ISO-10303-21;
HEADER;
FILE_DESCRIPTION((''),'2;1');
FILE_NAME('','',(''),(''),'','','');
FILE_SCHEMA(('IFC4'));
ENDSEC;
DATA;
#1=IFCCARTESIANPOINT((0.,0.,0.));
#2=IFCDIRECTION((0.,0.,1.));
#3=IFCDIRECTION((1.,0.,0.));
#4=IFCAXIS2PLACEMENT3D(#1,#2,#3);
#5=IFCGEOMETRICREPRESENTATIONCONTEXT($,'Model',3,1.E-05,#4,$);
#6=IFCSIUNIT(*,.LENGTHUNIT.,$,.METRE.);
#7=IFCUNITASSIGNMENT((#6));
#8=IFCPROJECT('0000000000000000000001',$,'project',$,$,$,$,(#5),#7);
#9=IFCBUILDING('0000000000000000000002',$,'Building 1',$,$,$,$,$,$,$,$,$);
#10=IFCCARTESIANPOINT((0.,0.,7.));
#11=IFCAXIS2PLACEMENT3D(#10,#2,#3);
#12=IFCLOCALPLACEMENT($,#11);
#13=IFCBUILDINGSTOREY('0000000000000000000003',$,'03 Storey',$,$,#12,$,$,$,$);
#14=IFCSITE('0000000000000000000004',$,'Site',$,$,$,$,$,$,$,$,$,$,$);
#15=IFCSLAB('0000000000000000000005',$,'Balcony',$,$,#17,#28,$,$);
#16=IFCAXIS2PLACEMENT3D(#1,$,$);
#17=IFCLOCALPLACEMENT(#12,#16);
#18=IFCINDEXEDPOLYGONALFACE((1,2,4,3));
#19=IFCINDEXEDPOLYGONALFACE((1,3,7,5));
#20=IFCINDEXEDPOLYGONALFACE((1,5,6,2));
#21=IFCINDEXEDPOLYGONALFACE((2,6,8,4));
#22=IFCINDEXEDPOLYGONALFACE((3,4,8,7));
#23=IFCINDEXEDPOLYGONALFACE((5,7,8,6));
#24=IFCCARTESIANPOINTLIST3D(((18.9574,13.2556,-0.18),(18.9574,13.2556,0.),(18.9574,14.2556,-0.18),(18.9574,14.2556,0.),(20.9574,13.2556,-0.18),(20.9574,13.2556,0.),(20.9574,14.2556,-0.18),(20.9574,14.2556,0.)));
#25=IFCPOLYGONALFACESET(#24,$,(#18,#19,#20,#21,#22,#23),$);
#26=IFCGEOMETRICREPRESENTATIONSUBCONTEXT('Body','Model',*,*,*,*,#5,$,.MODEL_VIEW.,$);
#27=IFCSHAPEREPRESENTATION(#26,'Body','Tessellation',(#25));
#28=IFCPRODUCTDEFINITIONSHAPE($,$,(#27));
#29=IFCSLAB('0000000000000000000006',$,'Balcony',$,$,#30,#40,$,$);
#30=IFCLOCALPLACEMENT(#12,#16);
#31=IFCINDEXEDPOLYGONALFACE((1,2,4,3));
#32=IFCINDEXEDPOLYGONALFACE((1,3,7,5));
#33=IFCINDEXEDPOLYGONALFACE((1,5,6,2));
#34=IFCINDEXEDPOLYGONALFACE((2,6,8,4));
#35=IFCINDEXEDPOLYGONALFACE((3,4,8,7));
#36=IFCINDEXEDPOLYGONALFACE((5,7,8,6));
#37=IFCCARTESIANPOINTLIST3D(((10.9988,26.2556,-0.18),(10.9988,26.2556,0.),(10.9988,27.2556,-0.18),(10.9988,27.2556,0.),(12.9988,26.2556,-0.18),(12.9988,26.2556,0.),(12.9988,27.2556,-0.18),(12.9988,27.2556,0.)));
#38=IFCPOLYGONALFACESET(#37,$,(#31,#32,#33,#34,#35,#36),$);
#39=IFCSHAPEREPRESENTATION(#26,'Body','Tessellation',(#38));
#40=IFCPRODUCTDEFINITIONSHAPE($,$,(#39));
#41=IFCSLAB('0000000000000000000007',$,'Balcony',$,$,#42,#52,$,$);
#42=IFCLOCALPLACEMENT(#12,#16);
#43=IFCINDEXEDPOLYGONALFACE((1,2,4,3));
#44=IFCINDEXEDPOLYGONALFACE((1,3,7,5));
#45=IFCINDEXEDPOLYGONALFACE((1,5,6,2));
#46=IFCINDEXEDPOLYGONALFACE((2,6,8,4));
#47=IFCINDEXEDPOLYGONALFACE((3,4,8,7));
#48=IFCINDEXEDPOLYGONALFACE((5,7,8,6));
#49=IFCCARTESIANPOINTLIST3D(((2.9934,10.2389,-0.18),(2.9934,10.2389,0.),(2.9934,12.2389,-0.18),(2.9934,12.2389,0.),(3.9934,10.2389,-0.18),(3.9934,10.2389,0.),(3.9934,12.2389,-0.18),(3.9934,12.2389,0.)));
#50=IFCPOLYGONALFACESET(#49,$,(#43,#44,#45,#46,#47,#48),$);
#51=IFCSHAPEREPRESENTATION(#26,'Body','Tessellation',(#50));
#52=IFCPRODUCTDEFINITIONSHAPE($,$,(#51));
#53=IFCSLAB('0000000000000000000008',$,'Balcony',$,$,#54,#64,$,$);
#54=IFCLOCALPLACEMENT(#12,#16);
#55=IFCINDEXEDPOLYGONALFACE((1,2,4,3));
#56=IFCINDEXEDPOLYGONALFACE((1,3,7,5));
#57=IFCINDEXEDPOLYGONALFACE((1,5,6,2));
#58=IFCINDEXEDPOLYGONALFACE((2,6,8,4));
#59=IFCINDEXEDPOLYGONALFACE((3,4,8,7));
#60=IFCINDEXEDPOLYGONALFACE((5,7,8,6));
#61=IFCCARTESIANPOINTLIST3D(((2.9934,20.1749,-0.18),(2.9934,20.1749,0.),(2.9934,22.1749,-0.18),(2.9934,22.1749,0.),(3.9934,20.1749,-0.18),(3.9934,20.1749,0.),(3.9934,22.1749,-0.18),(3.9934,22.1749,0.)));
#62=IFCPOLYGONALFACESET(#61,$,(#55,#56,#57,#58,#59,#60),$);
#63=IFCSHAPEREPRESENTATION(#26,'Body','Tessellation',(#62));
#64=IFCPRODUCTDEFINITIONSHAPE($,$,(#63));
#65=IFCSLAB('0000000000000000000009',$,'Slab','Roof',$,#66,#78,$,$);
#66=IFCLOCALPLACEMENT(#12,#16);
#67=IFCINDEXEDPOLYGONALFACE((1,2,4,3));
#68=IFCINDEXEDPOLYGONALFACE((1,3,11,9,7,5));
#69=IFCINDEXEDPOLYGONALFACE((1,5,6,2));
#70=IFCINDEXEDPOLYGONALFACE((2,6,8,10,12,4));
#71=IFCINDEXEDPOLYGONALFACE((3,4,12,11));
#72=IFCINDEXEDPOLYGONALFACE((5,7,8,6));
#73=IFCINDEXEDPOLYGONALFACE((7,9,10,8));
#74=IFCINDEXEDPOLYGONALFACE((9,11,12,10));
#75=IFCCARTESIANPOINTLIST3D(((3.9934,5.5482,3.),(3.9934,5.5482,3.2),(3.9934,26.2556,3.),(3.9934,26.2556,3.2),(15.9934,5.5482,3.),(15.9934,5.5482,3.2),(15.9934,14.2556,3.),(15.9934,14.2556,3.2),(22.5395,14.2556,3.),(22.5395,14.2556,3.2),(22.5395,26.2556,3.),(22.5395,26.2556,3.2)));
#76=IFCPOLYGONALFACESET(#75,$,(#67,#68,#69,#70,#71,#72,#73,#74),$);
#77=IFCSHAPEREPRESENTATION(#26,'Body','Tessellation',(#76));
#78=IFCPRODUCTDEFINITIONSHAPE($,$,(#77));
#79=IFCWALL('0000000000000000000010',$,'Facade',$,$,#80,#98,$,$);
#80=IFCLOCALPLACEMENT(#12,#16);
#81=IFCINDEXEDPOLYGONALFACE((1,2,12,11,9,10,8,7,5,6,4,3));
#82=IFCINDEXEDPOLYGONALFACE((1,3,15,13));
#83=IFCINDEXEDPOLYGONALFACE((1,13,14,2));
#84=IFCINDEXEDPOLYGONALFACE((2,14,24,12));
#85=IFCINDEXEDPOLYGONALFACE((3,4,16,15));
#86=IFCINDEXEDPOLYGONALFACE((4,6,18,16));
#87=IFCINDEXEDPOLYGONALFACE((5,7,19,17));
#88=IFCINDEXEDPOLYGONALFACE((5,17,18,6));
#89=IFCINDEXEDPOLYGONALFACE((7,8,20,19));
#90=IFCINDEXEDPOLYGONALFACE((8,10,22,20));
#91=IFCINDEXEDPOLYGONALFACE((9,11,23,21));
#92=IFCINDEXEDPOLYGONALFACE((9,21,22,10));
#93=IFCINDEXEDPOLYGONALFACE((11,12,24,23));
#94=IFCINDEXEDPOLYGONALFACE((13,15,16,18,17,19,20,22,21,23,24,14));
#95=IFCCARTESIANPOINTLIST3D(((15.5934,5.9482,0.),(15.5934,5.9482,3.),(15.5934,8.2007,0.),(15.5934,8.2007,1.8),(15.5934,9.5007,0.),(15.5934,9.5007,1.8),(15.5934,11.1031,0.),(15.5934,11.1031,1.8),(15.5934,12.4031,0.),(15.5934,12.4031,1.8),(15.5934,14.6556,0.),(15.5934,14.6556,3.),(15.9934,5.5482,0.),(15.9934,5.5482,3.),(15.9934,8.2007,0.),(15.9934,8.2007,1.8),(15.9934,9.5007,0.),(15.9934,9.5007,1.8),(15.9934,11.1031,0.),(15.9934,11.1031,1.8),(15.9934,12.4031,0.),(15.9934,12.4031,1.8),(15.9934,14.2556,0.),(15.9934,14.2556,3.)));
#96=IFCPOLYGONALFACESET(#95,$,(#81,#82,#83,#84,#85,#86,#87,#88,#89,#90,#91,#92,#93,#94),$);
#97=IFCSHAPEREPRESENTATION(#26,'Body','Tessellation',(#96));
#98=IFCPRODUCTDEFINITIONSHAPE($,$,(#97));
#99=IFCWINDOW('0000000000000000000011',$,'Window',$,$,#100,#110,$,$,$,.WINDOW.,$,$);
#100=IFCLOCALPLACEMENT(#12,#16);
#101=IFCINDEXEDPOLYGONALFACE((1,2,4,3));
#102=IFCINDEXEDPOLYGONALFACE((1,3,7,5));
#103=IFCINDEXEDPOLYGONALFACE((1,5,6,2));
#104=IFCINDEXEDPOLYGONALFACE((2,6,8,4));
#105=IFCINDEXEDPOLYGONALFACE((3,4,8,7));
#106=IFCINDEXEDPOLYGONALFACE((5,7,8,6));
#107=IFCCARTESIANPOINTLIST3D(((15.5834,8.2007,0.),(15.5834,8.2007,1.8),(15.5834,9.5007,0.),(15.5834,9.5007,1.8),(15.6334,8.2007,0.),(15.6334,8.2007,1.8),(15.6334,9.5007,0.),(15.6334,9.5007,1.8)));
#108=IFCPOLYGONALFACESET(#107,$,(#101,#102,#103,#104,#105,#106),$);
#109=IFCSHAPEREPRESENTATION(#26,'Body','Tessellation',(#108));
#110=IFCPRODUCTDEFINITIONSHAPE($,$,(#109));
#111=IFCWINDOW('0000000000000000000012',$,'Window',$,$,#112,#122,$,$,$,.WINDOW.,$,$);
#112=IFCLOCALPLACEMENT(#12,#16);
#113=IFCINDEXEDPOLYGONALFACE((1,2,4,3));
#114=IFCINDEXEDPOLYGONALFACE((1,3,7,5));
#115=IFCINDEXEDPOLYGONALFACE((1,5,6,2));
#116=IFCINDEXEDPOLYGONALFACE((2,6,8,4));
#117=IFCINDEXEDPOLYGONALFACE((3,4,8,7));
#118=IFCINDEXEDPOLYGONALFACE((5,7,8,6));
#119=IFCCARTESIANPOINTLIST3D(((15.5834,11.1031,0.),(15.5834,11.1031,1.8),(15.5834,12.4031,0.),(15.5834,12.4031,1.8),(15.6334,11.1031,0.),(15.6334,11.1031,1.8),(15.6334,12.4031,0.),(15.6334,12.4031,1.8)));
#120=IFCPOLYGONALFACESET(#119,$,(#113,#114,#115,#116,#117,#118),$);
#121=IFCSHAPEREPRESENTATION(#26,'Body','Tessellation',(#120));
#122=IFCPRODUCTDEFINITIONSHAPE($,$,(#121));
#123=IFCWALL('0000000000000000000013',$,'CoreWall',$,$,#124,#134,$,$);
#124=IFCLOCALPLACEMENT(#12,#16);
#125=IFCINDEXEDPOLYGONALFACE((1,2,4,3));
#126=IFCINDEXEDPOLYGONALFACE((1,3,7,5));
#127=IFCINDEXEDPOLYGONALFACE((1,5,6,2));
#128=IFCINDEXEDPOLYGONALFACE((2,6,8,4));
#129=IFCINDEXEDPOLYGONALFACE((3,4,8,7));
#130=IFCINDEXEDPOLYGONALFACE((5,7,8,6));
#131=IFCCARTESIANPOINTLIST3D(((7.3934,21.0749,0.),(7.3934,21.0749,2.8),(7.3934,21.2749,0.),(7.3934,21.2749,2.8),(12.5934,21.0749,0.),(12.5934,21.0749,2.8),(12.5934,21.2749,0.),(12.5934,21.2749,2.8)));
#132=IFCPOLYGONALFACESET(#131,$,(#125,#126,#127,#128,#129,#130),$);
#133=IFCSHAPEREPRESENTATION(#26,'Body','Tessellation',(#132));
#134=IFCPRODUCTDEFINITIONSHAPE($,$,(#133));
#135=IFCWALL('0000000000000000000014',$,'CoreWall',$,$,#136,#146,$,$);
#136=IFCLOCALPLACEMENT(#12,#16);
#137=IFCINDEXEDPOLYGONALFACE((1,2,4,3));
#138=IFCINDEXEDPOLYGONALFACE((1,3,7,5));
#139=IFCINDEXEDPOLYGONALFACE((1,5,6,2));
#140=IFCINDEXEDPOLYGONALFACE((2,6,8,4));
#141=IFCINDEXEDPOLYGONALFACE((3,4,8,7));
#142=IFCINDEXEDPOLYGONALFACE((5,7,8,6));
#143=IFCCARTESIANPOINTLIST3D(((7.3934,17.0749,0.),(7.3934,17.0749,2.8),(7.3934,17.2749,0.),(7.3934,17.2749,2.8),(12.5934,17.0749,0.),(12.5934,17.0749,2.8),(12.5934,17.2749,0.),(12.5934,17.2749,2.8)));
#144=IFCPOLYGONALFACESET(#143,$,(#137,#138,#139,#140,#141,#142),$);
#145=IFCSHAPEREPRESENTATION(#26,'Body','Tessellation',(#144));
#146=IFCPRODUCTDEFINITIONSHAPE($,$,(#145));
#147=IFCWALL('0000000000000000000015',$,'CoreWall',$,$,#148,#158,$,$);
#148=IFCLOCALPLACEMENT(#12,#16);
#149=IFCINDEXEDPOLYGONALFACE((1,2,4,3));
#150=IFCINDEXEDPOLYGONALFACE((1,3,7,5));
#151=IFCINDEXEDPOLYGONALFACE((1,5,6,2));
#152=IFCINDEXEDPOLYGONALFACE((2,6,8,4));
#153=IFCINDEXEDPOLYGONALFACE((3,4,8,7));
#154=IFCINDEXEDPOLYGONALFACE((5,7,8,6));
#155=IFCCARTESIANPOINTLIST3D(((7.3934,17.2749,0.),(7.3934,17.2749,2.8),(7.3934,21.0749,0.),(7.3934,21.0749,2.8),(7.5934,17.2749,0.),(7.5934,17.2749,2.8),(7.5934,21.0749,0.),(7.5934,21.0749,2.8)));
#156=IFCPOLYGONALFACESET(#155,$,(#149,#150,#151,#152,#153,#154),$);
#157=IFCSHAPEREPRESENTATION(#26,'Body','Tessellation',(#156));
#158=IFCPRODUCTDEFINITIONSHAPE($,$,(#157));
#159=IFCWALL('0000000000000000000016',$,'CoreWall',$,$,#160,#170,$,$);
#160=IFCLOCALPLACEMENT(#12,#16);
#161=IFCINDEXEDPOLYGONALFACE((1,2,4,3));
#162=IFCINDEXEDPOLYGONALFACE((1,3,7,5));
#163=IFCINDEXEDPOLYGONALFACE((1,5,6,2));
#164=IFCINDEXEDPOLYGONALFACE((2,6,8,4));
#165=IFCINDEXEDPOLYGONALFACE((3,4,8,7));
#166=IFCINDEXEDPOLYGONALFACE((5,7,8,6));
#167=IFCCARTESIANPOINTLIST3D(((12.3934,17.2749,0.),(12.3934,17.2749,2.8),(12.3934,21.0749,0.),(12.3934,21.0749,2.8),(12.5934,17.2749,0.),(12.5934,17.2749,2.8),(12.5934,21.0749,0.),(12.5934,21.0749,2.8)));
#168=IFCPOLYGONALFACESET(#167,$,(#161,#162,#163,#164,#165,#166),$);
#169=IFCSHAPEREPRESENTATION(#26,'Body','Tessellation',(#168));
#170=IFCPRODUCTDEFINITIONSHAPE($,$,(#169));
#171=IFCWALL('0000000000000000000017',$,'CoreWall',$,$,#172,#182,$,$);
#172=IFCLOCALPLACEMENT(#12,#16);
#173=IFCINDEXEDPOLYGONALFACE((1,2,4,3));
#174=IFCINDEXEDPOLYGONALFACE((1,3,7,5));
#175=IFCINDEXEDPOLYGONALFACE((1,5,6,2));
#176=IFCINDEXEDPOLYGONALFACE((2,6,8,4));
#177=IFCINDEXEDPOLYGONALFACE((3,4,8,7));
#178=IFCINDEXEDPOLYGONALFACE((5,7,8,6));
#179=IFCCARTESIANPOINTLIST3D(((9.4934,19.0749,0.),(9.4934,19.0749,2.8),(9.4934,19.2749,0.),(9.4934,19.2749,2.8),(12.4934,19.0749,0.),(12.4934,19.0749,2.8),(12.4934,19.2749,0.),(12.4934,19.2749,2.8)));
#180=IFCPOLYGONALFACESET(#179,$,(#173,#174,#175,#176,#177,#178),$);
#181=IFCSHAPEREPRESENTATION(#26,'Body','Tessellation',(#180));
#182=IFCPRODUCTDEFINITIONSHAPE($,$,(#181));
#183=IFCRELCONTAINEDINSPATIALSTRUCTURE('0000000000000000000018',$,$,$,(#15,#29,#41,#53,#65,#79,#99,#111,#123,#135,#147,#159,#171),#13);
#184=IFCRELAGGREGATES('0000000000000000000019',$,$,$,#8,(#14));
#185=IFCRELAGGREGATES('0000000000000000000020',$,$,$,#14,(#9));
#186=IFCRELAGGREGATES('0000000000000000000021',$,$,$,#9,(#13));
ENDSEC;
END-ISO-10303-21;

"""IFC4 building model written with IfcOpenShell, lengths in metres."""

from ifc_helpers import new_model, si_unit, frame, origin_with_axes, place, context, subcontext, project, spatial, polyline, line, indexed_curve, outline, extrude, element, fill, save


model = new_model("IFC4")

# Units and contexts
model_context = context("Model", 3, precision=1e-05, world=origin_with_axes())
body_context = subcontext(model_context, "Body", "Model", "MODEL_VIEW")
ifc_project = project(units=[si_unit("LENGTHUNIT", "METRE")], contexts=[model_context])

# Site, building, storey
site = spatial("IfcSite", under=ifc_project, Name="Site")
building = spatial("IfcBuilding", under=site, Name="Building 1")
storey_placement = place(None, frame((0.0, 0.0, 7.0), z_axis=(0.0, 0.0, 1.0), x_axis=(1.0, 0.0, 0.0)))
storey = spatial("IfcBuildingStorey", under=building, at=storey_placement, Name="03 Storey")

# Slabs
slab_1_placement = place(storey_placement, origin_with_axes())
element("IfcSlab", 1, at=slab_1_placement, inside=storey, Name="Balcony", context=body_context, shape_type="SweptSolid", body=[
    extrude(outline(indexed_curve([(20.9574, 14.2556), (20.9574, 13.2556), (18.9574, 13.2556), (18.9574, 14.2556)], segments=[line(1, 2), line(2, 3), line(3, 4)])), origin_with_axes(), (0.0, 0.0, -1.0), 0.18),
])
slab_2_placement = place(storey_placement, origin_with_axes())
element("IfcSlab", 2, at=slab_2_placement, inside=storey, Name="Balcony", context=body_context, shape_type="SweptSolid", body=[
    extrude(outline(indexed_curve([(10.9988, 26.2556), (10.9988, 27.2556), (12.9988, 27.2556), (12.9988, 26.2556)], segments=[line(1, 2), line(2, 3), line(3, 4)])), origin_with_axes(), (0.0, 0.0, -1.0), 0.18),
])
slab_3_placement = place(storey_placement, origin_with_axes())
element("IfcSlab", 3, at=slab_3_placement, inside=storey, Name="Balcony", context=body_context, shape_type="SweptSolid", body=[
    extrude(outline(indexed_curve([(3.9934, 10.2389), (2.9934, 10.2389), (2.9934, 12.2389), (3.9934, 12.2389)], segments=[line(1, 2), line(2, 3), line(3, 4)])), origin_with_axes(), (0.0, 0.0, -1.0), 0.18),
])
slab_4_placement = place(storey_placement, origin_with_axes())
element("IfcSlab", 4, at=slab_4_placement, inside=storey, Name="Balcony", context=body_context, shape_type="SweptSolid", body=[
    extrude(outline(indexed_curve([(3.9934, 20.1749), (2.9934, 20.1749), (2.9934, 22.1749), (3.9934, 22.1749)], segments=[line(1, 2), line(2, 3), line(3, 4)])), origin_with_axes(), (0.0, 0.0, -1.0), 0.18),
])
slab_5_placement = place(storey_placement, frame((15.9934, 14.2556, 0.0), z_axis=(0.0, 0.0, 1.0), x_axis=(1.0, 0.0, 0.0)))
element("IfcSlab", 5, at=slab_5_placement, inside=storey, Name="Slab", Description="Roof", context=body_context, shape_type="SweptSolid", body=[
    extrude(outline(polyline([(0.0, 0.0), (6.5461, 0.0), (6.5461, 12.0), (-12.0, 12.0), (-12.0, -8.7074), (0.0, -8.7074), (0.0, 0.0)])), frame((0.0, 0.0, 3.0), z_axis=(0.0, 0.0, 1.0), x_axis=(1.0, 0.0, 0.0)), (0.0, 0.0, 1.0), 0.2),
])

# Wall, openings, windows
wall_1_placement = place(storey_placement, origin_with_axes())
wall_1 = element("IfcWall", 6, at=wall_1_placement, inside=storey, Name="Facade", context=body_context, shape_type="SweptSolid", body=[
    extrude(outline(indexed_curve([(15.5934, 5.9482), (15.5934, 14.6556), (15.9934, 14.2556), (15.9934, 5.5482)], segments=[line(1, 2), line(2, 3), line(3, 4)])), origin_with_axes(), (0.0, 0.0, 1.0), 3.0),
])
opening_1_placement = place(wall_1_placement, origin_with_axes())
opening_1 = element("IfcOpeningElement", 7, at=opening_1_placement, cuts=wall_1, context=body_context, shape_type="SweptSolid", body=[
    extrude(outline(indexed_curve([(16.0334, 8.2007), (15.5334, 8.2007), (15.5334, 9.5007), (16.0334, 9.5007)], segments=[line(1, 2), line(2, 3), line(3, 4)])), origin_with_axes(), (0.0, 0.0, 1.0), 1.8),
])
opening_2_placement = place(wall_1_placement, origin_with_axes())
opening_2 = element("IfcOpeningElement", 8, at=opening_2_placement, cuts=wall_1, context=body_context, shape_type="SweptSolid", body=[
    extrude(outline(indexed_curve([(16.0334, 11.1031), (15.5334, 11.1031), (15.5334, 12.4031), (16.0334, 12.4031)], segments=[line(1, 2), line(2, 3), line(3, 4)])), origin_with_axes(), (0.0, 0.0, 1.0), 1.8),
])
window_1_placement = place(storey_placement, origin_with_axes())
window_1 = element("IfcWindow", 9, at=window_1_placement, inside=storey, Name="Window", PredefinedType="WINDOW", context=body_context, shape_type="SweptSolid", body=[
    extrude(outline(indexed_curve([(15.6334, 8.2007), (15.5834, 8.2007), (15.5834, 9.5007), (15.6334, 9.5007)], segments=[line(1, 2), line(2, 3), line(3, 4)])), origin_with_axes(), (0.0, 0.0, 1.0), 1.8),
])
fill(opening_1, window_1)
window_2_placement = place(storey_placement, origin_with_axes())
window_2 = element("IfcWindow", 10, at=window_2_placement, inside=storey, Name="Window", PredefinedType="WINDOW", context=body_context, shape_type="SweptSolid", body=[
    extrude(outline(indexed_curve([(15.6334, 11.1031), (15.5834, 11.1031), (15.5834, 12.4031), (15.6334, 12.4031)], segments=[line(1, 2), line(2, 3), line(3, 4)])), origin_with_axes(), (0.0, 0.0, 1.0), 1.8),
])
fill(opening_2, window_2)

# Walls
wall_2_placement = place(storey_placement, origin_with_axes())
element("IfcWall", 11, at=wall_2_placement, inside=storey, Name="CoreWall", context=body_context, shape_type="SweptSolid", body=[
    extrude(outline(indexed_curve([(12.5934, 21.2749), (7.3934, 21.2749), (7.3934, 21.0749), (12.5934, 21.0749)], segments=[line(1, 2), line(2, 3), line(3, 4)])), origin_with_axes(), (0.0, 0.0, 1.0), 2.8),
])
wall_3_placement = place(storey_placement, origin_with_axes())
element("IfcWall", 12, at=wall_3_placement, inside=storey, Name="CoreWall", context=body_context, shape_type="SweptSolid", body=[
    extrude(outline(indexed_curve([(7.3934, 17.0749), (12.5934, 17.0749), (12.5934, 17.2749), (7.3934, 17.2749)], segments=[line(1, 2), line(2, 3), line(3, 4)])), origin_with_axes(), (0.0, 0.0, 1.0), 2.8),
])
wall_4_placement = place(storey_placement, origin_with_axes())
element("IfcWall", 13, at=wall_4_placement, inside=storey, Name="CoreWall", context=body_context, shape_type="SweptSolid", body=[
    extrude(outline(indexed_curve([(7.5934, 17.2749), (7.5934, 21.0749), (7.3934, 21.0749), (7.3934, 17.2749)], segments=[line(1, 2), line(2, 3), line(3, 4)])), origin_with_axes(), (0.0, 0.0, 1.0), 2.8),
])
wall_5_placement = place(storey_placement, origin_with_axes())
element("IfcWall", 14, at=wall_5_placement, inside=storey, Name="CoreWall", context=body_context, shape_type="SweptSolid", body=[
    extrude(outline(indexed_curve([(12.3934, 21.0749), (12.3934, 17.2749), (12.5934, 17.2749), (12.5934, 21.0749)], segments=[line(1, 2), line(2, 3), line(3, 4)])), origin_with_axes(), (0.0, 0.0, 1.0), 2.8),
])
wall_6_placement = place(storey_placement, origin_with_axes())
element("IfcWall", 15, at=wall_6_placement, inside=storey, Name="CoreWall", context=body_context, shape_type="SweptSolid", body=[
    extrude(outline(indexed_curve([(12.4934, 19.2749), (9.4934, 19.2749), (9.4934, 19.0749), (12.4934, 19.0749)], segments=[line(1, 2), line(2, 3), line(3, 4)])), origin_with_axes(), (0.0, 0.0, 1.0), 2.8),
])

save(model, "model.ifc")
